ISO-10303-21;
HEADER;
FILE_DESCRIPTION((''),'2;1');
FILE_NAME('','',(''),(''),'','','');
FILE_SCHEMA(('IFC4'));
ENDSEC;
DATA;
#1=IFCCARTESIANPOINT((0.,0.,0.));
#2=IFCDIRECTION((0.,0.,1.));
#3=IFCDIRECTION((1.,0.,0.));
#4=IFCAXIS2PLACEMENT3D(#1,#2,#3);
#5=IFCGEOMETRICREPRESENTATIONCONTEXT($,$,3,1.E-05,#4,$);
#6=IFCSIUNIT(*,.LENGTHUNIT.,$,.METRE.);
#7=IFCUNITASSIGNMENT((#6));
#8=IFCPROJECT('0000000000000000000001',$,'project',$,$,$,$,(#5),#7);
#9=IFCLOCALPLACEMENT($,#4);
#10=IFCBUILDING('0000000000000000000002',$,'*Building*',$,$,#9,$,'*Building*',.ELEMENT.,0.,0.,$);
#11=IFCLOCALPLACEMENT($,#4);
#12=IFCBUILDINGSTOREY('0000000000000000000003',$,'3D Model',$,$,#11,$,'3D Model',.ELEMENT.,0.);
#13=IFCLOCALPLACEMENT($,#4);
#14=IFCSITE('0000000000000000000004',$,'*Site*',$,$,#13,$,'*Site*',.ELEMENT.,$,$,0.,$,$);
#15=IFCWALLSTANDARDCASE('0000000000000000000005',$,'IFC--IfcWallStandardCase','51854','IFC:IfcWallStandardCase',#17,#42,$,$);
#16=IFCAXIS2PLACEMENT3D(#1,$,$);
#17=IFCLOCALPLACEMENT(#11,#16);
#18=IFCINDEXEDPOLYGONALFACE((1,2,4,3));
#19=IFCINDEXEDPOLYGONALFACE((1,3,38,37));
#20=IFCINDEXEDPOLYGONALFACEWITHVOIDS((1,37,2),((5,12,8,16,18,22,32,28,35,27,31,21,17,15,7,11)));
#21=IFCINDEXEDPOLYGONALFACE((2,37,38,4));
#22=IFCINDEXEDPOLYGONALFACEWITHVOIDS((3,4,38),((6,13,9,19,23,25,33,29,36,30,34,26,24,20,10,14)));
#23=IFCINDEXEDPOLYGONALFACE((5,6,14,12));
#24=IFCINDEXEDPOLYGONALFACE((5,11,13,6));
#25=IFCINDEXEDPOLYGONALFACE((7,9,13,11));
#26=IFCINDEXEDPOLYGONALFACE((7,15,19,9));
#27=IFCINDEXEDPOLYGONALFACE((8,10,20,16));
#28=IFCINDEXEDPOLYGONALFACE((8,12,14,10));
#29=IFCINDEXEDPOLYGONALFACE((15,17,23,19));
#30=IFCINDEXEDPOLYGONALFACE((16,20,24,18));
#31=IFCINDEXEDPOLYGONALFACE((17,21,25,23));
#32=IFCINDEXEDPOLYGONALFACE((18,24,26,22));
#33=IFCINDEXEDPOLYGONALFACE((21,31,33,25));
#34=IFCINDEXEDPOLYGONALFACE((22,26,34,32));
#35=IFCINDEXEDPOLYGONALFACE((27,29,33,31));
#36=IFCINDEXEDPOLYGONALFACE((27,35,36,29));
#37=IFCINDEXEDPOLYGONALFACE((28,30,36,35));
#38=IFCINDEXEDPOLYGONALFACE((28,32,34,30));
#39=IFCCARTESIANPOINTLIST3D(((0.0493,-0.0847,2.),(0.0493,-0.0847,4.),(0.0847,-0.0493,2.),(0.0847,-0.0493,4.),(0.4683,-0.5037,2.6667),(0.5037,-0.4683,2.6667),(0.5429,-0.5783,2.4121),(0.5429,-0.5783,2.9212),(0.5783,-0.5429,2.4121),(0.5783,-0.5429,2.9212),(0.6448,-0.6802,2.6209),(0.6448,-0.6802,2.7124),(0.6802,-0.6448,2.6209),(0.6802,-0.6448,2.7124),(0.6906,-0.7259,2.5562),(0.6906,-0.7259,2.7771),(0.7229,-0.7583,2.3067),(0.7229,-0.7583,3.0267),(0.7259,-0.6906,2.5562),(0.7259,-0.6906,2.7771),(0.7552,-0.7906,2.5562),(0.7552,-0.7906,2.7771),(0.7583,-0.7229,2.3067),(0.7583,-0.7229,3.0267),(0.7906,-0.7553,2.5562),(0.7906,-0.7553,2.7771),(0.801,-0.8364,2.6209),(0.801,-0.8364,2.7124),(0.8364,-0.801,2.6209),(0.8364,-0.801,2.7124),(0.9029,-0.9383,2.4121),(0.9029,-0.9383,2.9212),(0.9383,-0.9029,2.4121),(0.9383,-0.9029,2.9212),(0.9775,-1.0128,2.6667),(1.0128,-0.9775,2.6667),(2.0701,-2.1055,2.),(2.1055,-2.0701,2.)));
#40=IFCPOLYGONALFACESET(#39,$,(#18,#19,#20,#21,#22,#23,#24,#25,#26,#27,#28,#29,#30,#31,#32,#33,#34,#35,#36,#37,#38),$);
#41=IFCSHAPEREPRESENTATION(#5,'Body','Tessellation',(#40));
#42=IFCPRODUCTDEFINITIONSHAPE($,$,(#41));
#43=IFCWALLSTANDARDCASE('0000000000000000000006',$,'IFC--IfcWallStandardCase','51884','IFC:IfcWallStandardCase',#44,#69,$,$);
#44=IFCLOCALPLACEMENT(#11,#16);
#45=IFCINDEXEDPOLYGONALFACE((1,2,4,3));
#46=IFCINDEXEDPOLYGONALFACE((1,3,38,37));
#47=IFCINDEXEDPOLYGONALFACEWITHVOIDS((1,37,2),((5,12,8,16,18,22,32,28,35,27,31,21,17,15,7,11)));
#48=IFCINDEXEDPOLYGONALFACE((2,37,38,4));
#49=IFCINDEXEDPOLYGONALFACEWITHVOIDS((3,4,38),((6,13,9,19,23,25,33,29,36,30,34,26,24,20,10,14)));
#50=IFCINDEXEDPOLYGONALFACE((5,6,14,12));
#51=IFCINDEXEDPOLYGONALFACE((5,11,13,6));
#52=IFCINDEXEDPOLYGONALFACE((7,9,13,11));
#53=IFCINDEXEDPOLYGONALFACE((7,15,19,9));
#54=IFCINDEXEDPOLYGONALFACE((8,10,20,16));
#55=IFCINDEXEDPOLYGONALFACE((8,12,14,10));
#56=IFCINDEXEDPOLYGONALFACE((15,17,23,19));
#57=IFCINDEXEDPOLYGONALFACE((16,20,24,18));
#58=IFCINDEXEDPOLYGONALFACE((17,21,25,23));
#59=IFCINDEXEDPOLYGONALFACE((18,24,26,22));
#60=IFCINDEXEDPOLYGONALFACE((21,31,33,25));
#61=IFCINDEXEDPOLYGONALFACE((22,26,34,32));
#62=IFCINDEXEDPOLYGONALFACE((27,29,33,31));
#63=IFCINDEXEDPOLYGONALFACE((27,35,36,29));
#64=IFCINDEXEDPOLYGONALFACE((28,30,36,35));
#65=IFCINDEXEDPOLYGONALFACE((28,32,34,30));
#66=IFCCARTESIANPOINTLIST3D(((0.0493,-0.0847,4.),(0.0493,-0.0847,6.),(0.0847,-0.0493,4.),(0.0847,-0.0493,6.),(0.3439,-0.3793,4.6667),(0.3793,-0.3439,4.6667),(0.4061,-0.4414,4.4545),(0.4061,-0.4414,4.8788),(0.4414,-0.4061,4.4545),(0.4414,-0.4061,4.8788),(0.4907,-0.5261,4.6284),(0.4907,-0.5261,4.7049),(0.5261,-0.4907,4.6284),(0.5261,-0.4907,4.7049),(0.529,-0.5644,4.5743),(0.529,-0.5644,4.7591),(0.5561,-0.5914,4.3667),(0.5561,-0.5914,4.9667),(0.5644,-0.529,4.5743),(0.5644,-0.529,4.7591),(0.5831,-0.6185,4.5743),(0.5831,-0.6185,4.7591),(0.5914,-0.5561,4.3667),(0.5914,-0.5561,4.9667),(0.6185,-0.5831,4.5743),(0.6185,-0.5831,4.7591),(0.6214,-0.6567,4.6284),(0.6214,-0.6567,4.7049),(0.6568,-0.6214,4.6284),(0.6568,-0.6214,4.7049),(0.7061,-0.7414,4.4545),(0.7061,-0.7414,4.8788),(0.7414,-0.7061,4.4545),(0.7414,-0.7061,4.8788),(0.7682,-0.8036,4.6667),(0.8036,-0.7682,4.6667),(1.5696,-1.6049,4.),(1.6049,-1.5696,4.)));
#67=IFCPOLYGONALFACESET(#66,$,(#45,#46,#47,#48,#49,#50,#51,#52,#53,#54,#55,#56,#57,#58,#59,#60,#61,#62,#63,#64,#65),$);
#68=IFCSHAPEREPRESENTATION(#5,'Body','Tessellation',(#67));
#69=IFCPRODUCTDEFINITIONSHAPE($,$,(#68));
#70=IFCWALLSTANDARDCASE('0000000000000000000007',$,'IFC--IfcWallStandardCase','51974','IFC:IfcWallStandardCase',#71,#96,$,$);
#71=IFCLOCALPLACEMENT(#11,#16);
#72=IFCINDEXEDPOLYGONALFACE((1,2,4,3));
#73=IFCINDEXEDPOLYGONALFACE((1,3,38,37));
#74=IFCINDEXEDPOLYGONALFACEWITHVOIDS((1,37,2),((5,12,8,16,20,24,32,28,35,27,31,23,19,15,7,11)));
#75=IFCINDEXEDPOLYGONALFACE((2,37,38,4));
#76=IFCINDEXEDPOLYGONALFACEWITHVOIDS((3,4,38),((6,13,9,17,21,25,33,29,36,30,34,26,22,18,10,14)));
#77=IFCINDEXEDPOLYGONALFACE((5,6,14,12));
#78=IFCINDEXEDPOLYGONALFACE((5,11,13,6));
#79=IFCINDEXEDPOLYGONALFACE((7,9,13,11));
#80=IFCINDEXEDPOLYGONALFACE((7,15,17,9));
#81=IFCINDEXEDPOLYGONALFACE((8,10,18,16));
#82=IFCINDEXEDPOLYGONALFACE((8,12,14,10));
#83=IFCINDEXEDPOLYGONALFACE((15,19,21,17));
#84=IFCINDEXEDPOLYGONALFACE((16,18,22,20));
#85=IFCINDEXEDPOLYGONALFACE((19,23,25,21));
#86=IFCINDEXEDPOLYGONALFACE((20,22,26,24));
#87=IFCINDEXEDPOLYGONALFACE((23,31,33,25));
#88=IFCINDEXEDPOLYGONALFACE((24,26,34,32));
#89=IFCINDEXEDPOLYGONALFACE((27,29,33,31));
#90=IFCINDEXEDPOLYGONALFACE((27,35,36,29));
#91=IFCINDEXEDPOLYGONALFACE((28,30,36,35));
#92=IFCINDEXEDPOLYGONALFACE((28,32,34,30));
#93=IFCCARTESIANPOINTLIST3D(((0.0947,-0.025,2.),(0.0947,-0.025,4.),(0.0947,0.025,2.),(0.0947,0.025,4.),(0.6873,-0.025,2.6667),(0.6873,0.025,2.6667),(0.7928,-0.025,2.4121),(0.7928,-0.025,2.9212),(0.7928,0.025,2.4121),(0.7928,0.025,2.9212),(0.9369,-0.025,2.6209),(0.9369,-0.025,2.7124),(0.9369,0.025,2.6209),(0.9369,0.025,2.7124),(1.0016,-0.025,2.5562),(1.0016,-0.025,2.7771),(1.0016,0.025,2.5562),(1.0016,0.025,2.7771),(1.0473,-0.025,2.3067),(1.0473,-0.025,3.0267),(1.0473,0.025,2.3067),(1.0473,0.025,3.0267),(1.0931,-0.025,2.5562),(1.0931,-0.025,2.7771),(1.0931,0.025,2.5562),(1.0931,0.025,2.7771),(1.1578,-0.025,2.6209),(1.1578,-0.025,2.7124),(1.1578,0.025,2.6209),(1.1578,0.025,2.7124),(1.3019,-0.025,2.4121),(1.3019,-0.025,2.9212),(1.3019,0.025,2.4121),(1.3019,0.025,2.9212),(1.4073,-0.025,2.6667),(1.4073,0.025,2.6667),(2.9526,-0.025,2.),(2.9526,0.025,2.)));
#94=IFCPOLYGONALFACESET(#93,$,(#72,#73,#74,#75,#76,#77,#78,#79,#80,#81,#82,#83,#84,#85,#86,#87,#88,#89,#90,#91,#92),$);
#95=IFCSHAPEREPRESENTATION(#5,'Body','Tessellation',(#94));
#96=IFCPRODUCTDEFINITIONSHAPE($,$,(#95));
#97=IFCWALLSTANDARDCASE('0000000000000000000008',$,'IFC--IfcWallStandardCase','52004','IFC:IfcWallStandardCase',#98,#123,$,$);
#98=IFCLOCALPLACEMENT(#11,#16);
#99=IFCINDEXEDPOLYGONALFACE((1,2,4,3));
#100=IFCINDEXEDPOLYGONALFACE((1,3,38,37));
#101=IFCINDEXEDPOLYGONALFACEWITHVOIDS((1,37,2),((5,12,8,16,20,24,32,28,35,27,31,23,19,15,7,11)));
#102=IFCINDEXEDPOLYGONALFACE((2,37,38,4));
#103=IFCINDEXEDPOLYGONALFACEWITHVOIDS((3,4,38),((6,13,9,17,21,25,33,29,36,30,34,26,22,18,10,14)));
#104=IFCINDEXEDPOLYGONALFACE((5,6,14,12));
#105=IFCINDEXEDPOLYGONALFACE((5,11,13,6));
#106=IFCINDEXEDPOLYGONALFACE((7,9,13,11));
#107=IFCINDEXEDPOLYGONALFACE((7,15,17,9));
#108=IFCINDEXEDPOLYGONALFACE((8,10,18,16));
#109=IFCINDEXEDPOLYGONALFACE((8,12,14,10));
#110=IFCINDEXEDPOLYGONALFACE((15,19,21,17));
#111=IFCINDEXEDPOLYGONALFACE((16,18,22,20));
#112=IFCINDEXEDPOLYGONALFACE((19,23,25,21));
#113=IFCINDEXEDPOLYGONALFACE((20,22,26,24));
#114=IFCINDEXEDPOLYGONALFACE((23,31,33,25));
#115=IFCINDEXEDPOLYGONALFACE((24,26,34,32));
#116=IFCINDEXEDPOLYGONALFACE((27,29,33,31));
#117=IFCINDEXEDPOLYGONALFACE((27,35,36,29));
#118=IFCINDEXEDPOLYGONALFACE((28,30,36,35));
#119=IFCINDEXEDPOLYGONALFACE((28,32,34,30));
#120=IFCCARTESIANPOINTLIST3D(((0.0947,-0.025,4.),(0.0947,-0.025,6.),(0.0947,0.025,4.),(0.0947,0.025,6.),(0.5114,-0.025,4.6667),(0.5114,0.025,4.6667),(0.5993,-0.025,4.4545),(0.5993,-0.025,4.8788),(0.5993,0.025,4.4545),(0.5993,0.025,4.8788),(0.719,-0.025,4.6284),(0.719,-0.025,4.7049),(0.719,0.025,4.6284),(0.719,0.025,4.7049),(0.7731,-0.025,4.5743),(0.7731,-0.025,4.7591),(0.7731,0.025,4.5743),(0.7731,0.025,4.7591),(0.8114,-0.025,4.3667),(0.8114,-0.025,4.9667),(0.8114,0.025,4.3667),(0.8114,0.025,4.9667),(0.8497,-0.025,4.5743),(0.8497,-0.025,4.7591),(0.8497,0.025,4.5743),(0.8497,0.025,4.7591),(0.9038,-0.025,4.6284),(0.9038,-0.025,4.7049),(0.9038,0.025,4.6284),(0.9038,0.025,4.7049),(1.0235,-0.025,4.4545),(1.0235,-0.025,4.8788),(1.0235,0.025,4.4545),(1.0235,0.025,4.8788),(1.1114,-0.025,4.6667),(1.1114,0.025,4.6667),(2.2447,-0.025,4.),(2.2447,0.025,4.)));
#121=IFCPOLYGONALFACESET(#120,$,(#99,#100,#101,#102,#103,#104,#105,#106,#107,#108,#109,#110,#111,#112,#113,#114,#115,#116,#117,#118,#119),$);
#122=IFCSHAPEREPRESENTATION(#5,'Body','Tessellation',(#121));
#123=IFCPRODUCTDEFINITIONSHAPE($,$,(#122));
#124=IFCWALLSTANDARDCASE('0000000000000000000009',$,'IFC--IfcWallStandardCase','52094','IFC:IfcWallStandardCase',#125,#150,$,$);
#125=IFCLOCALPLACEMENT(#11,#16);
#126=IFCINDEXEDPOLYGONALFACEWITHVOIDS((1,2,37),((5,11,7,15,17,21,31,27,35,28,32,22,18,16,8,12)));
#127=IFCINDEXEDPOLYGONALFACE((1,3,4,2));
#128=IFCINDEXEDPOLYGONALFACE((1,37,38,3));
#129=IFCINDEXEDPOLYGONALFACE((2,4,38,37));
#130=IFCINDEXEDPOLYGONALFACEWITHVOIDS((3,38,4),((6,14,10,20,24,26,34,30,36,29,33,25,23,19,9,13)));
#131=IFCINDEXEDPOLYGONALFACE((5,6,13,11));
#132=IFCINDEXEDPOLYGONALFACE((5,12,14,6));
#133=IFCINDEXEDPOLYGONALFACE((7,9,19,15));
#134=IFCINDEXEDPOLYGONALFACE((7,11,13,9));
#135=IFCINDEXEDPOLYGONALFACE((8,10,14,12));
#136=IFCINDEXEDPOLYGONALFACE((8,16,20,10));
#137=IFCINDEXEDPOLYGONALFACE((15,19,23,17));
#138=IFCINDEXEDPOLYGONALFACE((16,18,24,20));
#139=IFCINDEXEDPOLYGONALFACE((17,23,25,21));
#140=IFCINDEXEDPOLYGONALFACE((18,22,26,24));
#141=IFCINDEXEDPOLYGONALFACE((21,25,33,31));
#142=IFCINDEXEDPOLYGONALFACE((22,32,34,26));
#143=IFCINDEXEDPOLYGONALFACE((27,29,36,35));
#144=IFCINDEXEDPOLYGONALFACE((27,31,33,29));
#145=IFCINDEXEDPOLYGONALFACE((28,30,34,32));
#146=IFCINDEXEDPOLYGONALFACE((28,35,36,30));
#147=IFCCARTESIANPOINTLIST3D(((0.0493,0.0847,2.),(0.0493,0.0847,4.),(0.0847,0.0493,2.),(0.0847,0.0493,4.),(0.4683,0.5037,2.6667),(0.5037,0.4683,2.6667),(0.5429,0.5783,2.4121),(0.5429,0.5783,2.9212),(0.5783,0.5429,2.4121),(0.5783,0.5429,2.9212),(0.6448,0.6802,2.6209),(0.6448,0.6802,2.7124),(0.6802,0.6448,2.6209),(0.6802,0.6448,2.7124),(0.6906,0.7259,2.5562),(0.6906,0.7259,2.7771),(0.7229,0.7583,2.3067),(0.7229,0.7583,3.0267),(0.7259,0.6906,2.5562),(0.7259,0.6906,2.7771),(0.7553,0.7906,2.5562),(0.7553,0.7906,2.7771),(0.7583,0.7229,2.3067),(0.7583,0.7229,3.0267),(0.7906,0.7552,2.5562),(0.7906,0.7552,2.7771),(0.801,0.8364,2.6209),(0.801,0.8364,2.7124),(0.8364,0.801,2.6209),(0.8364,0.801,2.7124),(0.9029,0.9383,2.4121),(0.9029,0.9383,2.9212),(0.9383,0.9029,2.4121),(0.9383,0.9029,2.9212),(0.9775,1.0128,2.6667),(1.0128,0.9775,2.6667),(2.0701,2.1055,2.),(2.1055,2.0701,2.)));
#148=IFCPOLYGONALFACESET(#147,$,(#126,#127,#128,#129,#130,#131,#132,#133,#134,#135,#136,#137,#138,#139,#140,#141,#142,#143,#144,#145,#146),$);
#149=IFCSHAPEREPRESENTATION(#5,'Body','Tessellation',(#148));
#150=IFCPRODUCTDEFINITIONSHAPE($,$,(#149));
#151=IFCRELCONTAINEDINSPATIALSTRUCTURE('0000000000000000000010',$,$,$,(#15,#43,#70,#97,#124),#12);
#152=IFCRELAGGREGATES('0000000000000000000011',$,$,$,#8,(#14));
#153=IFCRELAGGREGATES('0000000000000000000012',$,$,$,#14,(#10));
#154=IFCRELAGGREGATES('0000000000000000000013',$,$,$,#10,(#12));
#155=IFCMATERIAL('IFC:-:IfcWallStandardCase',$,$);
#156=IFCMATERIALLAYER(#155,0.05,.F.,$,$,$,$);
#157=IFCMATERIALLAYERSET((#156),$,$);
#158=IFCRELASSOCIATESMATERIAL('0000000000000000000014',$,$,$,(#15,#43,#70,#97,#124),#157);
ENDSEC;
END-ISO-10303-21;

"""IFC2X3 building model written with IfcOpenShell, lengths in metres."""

from ifc_helpers import new_model, si_unit, frame, frame_2d, origin_with_axes, place, context, project, spatial, polyline, rectangle, outline, extrude, clip, halfspace, material, layer, layer_set, layer_usage, element, save


model = new_model("IFC2X3")

# Units and contexts
context_of_model = context(None, 3, precision=1e-05, world=origin_with_axes())
ifc_project = project(units=[si_unit("LENGTHUNIT", "METRE")], contexts=[context_of_model])

# Site, building, storey
site_placement = place(None, origin_with_axes())
site = spatial("IfcSite", under=ifc_project, at=site_placement, Name="*Site*", LongName="*Site*", CompositionType="ELEMENT", RefElevation=0.0)
building_placement = place(None, origin_with_axes())
building = spatial("IfcBuilding", under=site, at=building_placement, Name="*Building*", LongName="*Building*", CompositionType="ELEMENT", ElevationOfRefHeight=0.0, ElevationOfTerrain=0.0)
storey_placement = place(None, origin_with_axes())
storey = spatial("IfcBuildingStorey", under=building, at=storey_placement, Name="3D Model", LongName="3D Model", CompositionType="ELEMENT", Elevation=0.0)

# Walls, openings
ifc_material = material(Name="IFC:-:IfcWallStandardCase")
ifc_layer = layer(ifc_material, 0.05, ventilated=False)
ifc_layer_set = layer_set([ifc_layer])
ifc_layer_usage = layer_usage(ifc_layer_set, "AXIS2", "POSITIVE", 0.0)
wall_1_placement = place(None, frame((0.067, -0.067, 2.0), z_axis=(0.0, 0.0, 1.0), x_axis=(0.707107, -0.707107, 0.0)))
wall_1 = element("IfcWallStandardCase", 1, at=wall_1_placement, inside=storey, material=ifc_layer_usage, Name="IFC--IfcWallStandardCase", Description="51854", ObjectType="IFC:IfcWallStandardCase", context=context_of_model, shape_type="Clipping", body=[
    clip(extrude(rectangle(XDim=2.8578, YDim=0.05, at=frame_2d((1.4289, 0.0), x_axis=(1.0, 0.0))), origin_with_axes(), (0.0, 0.0, 1.0), 2.0), halfspace(frame((0.9395, 0.0, 1.3425), z_axis=(-0.573369, 0.0, -0.819297), x_axis=(-0.819297, 0.0, 0.573369)), True)),
])
opening_1_placement = place(wall_1_placement, frame((0.5926, -0.025, 0.3067), z_axis=(0.0, 0.0, 1.0), x_axis=(1.0, 0.0, 0.0)))
element("IfcOpeningElement", 2, at=opening_1_placement, cuts=wall_1, context=context_of_model, shape_type="SweptSolid", body=[
    extrude(outline(polyline([(-0.4704, 0.3143), (-0.6146, 0.1054), (-0.4057, 0.2496), (-0.36, 0.0), (-0.3143, 0.2496), (-0.1054, 0.1054), (-0.2496, 0.3143), (0.0, 0.36), (-0.2496, 0.4057), (-0.1054, 0.6146), (-0.3143, 0.4704), (-0.36, 0.72), (-0.4057, 0.4704), (-0.6146, 0.6146), (-0.4704, 0.4057), (-0.72, 0.36), (-0.4704, 0.3143)])), frame((0.0, 0.0, 0.0), z_axis=(-0.000003, 1.0, 0.0), x_axis=(-1.0, -0.000003, 0.0)), (0.0, 0.0, 1.0), 0.075),
])
wall_2_placement = place(None, frame((0.067, -0.067, 4.0), z_axis=(0.0, 0.0, 1.0), x_axis=(0.707109, -0.707105, 0.0)))
wall_2 = element("IfcWallStandardCase", 3, at=wall_2_placement, inside=storey, material=ifc_layer_usage, Name="IFC--IfcWallStandardCase", Description="51884", ObjectType="IFC:IfcWallStandardCase", context=context_of_model, shape_type="Clipping", body=[
    clip(extrude(rectangle(XDim=2.15, YDim=0.05, at=frame_2d((1.075, 0.0), x_axis=(1.0, 0.0))), origin_with_axes(), (0.0, 0.0, 1.0), 2.0), halfspace(frame((0.9974, 0.0, 1.0722), z_axis=(-0.681104, 0.000002, -0.732187), x_axis=(-0.732187, 0.0, 0.681104)), True)),
])
opening_2_placement = place(wall_2_placement, frame((0.4167, -0.025, 0.3667), z_axis=(0.0, 0.0, 1.0), x_axis=(1.0, 0.0, 0.0)))
element("IfcOpeningElement", 4, at=opening_2_placement, cuts=wall_2, context=context_of_model, shape_type="SweptSolid", body=[
    extrude(outline(polyline([(-0.3924, 0.2617), (-0.5121, 0.0879), (-0.3383, 0.2076), (-0.3, 0.0), (-0.2617, 0.2076), (-0.0879, 0.0879), (-0.2076, 0.2617), (0.0, 0.3), (-0.2076, 0.3383), (-0.0879, 0.5121), (-0.2617, 0.3924), (-0.3, 0.6), (-0.3383, 0.3924), (-0.5121, 0.5121), (-0.3924, 0.3383), (-0.6, 0.3), (-0.3924, 0.2617)])), frame((0.0, 0.0, 0.0), z_axis=(0.0, 1.0, 0.0), x_axis=(-1.0, 0.0, 0.0)), (0.0, 0.0, 1.0), 0.075),
])
wall_3_placement = place(None, frame((0.0947, 0.0, 2.0), z_axis=(0.0, 0.0, 1.0), x_axis=(1.0, 0.0, 0.0)))
wall_3 = element("IfcWallStandardCase", 5, at=wall_3_placement, inside=storey, material=ifc_layer_usage, Name="IFC--IfcWallStandardCase", Description="51974", ObjectType="IFC:IfcWallStandardCase", context=context_of_model, shape_type="Clipping", body=[
    clip(extrude(rectangle(XDim=2.8578, YDim=0.05, at=frame_2d((1.4289, 0.0), x_axis=(1.0, 0.0))), origin_with_axes(), (0.0, 0.0, 1.0), 2.0), halfspace(frame((0.9395, 0.0, 1.3425), z_axis=(-0.573369, 0.0, -0.819297), x_axis=(-0.819297, 0.0, 0.573369)), True)),
])
opening_3_placement = place(wall_3_placement, frame((0.5926, -0.025, 0.3067), z_axis=(0.0, 0.0, 1.0), x_axis=(1.0, 0.0, 0.0)))
element("IfcOpeningElement", 6, at=opening_3_placement, cuts=wall_3, context=context_of_model, shape_type="SweptSolid", body=[
    extrude(outline(polyline([(-0.4704, 0.3143), (-0.6146, 0.1054), (-0.4057, 0.2496), (-0.36, 0.0), (-0.3143, 0.2496), (-0.1054, 0.1054), (-0.2496, 0.3143), (0.0, 0.36), (-0.2496, 0.4057), (-0.1054, 0.6146), (-0.3143, 0.4704), (-0.36, 0.72), (-0.4057, 0.4704), (-0.6146, 0.6146), (-0.4704, 0.4057), (-0.72, 0.36), (-0.4704, 0.3143)])), frame((0.0, 0.0, 0.0), z_axis=(-0.000003, 1.0, 0.0), x_axis=(-1.0, -0.000003, 0.0)), (0.0, 0.0, 1.0), 0.075),
])
wall_4_placement = place(None, frame((0.0947, 0.0, 4.0), z_axis=(0.0, 0.0, 1.0), x_axis=(1.0, 0.000003, 0.0)))
wall_4 = element("IfcWallStandardCase", 7, at=wall_4_placement, inside=storey, material=ifc_layer_usage, Name="IFC--IfcWallStandardCase", Description="52004", ObjectType="IFC:IfcWallStandardCase", context=context_of_model, shape_type="Clipping", body=[
    clip(extrude(rectangle(XDim=2.15, YDim=0.05, at=frame_2d((1.075, 0.0), x_axis=(1.0, 0.0))), origin_with_axes(), (0.0, 0.0, 1.0), 2.0), halfspace(frame((0.9974, 0.0, 1.0722), z_axis=(-0.681104, 0.000002, -0.732187), x_axis=(-0.732187, 0.0, 0.681104)), True)),
])
opening_4_placement = place(wall_4_placement, frame((0.4167, -0.025, 0.3667), z_axis=(0.0, 0.0, 1.0), x_axis=(1.0, 0.0, 0.0)))
element("IfcOpeningElement", 8, at=opening_4_placement, cuts=wall_4, context=context_of_model, shape_type="SweptSolid", body=[
    extrude(outline(polyline([(-0.3924, 0.2617), (-0.5121, 0.0879), (-0.3383, 0.2076), (-0.3, 0.0), (-0.2617, 0.2076), (-0.0879, 0.0879), (-0.2076, 0.2617), (0.0, 0.3), (-0.2076, 0.3383), (-0.0879, 0.5121), (-0.2617, 0.3924), (-0.3, 0.6), (-0.3383, 0.3924), (-0.5121, 0.5121), (-0.3924, 0.3383), (-0.6, 0.3), (-0.3924, 0.2617)])), frame((0.0, 0.0, 0.0), z_axis=(0.0, 1.0, 0.0), x_axis=(-1.0, 0.0, 0.0)), (0.0, 0.0, 1.0), 0.075),
])
wall_5_placement = place(None, frame((0.067, 0.067, 2.0), z_axis=(0.0, 0.0, 1.0), x_axis=(0.707107, 0.707107, 0.0)))
wall_5 = element("IfcWallStandardCase", 9, at=wall_5_placement, inside=storey, material=ifc_layer_usage, Name="IFC--IfcWallStandardCase", Description="52094", ObjectType="IFC:IfcWallStandardCase", context=context_of_model, shape_type="Clipping", body=[
    clip(extrude(rectangle(XDim=2.8578, YDim=0.05, at=frame_2d((1.4289, 0.0), x_axis=(1.0, 0.0))), origin_with_axes(), (0.0, 0.0, 1.0), 2.0), halfspace(frame((0.9395, 0.0, 1.3425), z_axis=(-0.573369, 0.0, -0.819297), x_axis=(-0.819297, 0.0, 0.573369)), True)),
])
opening_5_placement = place(wall_5_placement, frame((0.5926, -0.025, 0.3067), z_axis=(0.0, 0.0, 1.0), x_axis=(1.0, 0.0, 0.0)))
element("IfcOpeningElement", 10, at=opening_5_placement, cuts=wall_5, context=context_of_model, shape_type="SweptSolid", body=[
    extrude(outline(polyline([(-0.4704, 0.3143), (-0.6146, 0.1054), (-0.4057, 0.2496), (-0.36, 0.0), (-0.3143, 0.2496), (-0.1054, 0.1054), (-0.2496, 0.3143), (0.0, 0.36), (-0.2496, 0.4057), (-0.1054, 0.6146), (-0.3143, 0.4704), (-0.36, 0.72), (-0.4057, 0.4704), (-0.6146, 0.6146), (-0.4704, 0.4057), (-0.72, 0.36), (-0.4704, 0.3143)])), frame((0.0, 0.0, 0.0), z_axis=(-0.000003, 1.0, 0.0), x_axis=(-1.0, -0.000003, 0.0)), (0.0, 0.0, 1.0), 0.075),
])

save(model, "model.ifc")
